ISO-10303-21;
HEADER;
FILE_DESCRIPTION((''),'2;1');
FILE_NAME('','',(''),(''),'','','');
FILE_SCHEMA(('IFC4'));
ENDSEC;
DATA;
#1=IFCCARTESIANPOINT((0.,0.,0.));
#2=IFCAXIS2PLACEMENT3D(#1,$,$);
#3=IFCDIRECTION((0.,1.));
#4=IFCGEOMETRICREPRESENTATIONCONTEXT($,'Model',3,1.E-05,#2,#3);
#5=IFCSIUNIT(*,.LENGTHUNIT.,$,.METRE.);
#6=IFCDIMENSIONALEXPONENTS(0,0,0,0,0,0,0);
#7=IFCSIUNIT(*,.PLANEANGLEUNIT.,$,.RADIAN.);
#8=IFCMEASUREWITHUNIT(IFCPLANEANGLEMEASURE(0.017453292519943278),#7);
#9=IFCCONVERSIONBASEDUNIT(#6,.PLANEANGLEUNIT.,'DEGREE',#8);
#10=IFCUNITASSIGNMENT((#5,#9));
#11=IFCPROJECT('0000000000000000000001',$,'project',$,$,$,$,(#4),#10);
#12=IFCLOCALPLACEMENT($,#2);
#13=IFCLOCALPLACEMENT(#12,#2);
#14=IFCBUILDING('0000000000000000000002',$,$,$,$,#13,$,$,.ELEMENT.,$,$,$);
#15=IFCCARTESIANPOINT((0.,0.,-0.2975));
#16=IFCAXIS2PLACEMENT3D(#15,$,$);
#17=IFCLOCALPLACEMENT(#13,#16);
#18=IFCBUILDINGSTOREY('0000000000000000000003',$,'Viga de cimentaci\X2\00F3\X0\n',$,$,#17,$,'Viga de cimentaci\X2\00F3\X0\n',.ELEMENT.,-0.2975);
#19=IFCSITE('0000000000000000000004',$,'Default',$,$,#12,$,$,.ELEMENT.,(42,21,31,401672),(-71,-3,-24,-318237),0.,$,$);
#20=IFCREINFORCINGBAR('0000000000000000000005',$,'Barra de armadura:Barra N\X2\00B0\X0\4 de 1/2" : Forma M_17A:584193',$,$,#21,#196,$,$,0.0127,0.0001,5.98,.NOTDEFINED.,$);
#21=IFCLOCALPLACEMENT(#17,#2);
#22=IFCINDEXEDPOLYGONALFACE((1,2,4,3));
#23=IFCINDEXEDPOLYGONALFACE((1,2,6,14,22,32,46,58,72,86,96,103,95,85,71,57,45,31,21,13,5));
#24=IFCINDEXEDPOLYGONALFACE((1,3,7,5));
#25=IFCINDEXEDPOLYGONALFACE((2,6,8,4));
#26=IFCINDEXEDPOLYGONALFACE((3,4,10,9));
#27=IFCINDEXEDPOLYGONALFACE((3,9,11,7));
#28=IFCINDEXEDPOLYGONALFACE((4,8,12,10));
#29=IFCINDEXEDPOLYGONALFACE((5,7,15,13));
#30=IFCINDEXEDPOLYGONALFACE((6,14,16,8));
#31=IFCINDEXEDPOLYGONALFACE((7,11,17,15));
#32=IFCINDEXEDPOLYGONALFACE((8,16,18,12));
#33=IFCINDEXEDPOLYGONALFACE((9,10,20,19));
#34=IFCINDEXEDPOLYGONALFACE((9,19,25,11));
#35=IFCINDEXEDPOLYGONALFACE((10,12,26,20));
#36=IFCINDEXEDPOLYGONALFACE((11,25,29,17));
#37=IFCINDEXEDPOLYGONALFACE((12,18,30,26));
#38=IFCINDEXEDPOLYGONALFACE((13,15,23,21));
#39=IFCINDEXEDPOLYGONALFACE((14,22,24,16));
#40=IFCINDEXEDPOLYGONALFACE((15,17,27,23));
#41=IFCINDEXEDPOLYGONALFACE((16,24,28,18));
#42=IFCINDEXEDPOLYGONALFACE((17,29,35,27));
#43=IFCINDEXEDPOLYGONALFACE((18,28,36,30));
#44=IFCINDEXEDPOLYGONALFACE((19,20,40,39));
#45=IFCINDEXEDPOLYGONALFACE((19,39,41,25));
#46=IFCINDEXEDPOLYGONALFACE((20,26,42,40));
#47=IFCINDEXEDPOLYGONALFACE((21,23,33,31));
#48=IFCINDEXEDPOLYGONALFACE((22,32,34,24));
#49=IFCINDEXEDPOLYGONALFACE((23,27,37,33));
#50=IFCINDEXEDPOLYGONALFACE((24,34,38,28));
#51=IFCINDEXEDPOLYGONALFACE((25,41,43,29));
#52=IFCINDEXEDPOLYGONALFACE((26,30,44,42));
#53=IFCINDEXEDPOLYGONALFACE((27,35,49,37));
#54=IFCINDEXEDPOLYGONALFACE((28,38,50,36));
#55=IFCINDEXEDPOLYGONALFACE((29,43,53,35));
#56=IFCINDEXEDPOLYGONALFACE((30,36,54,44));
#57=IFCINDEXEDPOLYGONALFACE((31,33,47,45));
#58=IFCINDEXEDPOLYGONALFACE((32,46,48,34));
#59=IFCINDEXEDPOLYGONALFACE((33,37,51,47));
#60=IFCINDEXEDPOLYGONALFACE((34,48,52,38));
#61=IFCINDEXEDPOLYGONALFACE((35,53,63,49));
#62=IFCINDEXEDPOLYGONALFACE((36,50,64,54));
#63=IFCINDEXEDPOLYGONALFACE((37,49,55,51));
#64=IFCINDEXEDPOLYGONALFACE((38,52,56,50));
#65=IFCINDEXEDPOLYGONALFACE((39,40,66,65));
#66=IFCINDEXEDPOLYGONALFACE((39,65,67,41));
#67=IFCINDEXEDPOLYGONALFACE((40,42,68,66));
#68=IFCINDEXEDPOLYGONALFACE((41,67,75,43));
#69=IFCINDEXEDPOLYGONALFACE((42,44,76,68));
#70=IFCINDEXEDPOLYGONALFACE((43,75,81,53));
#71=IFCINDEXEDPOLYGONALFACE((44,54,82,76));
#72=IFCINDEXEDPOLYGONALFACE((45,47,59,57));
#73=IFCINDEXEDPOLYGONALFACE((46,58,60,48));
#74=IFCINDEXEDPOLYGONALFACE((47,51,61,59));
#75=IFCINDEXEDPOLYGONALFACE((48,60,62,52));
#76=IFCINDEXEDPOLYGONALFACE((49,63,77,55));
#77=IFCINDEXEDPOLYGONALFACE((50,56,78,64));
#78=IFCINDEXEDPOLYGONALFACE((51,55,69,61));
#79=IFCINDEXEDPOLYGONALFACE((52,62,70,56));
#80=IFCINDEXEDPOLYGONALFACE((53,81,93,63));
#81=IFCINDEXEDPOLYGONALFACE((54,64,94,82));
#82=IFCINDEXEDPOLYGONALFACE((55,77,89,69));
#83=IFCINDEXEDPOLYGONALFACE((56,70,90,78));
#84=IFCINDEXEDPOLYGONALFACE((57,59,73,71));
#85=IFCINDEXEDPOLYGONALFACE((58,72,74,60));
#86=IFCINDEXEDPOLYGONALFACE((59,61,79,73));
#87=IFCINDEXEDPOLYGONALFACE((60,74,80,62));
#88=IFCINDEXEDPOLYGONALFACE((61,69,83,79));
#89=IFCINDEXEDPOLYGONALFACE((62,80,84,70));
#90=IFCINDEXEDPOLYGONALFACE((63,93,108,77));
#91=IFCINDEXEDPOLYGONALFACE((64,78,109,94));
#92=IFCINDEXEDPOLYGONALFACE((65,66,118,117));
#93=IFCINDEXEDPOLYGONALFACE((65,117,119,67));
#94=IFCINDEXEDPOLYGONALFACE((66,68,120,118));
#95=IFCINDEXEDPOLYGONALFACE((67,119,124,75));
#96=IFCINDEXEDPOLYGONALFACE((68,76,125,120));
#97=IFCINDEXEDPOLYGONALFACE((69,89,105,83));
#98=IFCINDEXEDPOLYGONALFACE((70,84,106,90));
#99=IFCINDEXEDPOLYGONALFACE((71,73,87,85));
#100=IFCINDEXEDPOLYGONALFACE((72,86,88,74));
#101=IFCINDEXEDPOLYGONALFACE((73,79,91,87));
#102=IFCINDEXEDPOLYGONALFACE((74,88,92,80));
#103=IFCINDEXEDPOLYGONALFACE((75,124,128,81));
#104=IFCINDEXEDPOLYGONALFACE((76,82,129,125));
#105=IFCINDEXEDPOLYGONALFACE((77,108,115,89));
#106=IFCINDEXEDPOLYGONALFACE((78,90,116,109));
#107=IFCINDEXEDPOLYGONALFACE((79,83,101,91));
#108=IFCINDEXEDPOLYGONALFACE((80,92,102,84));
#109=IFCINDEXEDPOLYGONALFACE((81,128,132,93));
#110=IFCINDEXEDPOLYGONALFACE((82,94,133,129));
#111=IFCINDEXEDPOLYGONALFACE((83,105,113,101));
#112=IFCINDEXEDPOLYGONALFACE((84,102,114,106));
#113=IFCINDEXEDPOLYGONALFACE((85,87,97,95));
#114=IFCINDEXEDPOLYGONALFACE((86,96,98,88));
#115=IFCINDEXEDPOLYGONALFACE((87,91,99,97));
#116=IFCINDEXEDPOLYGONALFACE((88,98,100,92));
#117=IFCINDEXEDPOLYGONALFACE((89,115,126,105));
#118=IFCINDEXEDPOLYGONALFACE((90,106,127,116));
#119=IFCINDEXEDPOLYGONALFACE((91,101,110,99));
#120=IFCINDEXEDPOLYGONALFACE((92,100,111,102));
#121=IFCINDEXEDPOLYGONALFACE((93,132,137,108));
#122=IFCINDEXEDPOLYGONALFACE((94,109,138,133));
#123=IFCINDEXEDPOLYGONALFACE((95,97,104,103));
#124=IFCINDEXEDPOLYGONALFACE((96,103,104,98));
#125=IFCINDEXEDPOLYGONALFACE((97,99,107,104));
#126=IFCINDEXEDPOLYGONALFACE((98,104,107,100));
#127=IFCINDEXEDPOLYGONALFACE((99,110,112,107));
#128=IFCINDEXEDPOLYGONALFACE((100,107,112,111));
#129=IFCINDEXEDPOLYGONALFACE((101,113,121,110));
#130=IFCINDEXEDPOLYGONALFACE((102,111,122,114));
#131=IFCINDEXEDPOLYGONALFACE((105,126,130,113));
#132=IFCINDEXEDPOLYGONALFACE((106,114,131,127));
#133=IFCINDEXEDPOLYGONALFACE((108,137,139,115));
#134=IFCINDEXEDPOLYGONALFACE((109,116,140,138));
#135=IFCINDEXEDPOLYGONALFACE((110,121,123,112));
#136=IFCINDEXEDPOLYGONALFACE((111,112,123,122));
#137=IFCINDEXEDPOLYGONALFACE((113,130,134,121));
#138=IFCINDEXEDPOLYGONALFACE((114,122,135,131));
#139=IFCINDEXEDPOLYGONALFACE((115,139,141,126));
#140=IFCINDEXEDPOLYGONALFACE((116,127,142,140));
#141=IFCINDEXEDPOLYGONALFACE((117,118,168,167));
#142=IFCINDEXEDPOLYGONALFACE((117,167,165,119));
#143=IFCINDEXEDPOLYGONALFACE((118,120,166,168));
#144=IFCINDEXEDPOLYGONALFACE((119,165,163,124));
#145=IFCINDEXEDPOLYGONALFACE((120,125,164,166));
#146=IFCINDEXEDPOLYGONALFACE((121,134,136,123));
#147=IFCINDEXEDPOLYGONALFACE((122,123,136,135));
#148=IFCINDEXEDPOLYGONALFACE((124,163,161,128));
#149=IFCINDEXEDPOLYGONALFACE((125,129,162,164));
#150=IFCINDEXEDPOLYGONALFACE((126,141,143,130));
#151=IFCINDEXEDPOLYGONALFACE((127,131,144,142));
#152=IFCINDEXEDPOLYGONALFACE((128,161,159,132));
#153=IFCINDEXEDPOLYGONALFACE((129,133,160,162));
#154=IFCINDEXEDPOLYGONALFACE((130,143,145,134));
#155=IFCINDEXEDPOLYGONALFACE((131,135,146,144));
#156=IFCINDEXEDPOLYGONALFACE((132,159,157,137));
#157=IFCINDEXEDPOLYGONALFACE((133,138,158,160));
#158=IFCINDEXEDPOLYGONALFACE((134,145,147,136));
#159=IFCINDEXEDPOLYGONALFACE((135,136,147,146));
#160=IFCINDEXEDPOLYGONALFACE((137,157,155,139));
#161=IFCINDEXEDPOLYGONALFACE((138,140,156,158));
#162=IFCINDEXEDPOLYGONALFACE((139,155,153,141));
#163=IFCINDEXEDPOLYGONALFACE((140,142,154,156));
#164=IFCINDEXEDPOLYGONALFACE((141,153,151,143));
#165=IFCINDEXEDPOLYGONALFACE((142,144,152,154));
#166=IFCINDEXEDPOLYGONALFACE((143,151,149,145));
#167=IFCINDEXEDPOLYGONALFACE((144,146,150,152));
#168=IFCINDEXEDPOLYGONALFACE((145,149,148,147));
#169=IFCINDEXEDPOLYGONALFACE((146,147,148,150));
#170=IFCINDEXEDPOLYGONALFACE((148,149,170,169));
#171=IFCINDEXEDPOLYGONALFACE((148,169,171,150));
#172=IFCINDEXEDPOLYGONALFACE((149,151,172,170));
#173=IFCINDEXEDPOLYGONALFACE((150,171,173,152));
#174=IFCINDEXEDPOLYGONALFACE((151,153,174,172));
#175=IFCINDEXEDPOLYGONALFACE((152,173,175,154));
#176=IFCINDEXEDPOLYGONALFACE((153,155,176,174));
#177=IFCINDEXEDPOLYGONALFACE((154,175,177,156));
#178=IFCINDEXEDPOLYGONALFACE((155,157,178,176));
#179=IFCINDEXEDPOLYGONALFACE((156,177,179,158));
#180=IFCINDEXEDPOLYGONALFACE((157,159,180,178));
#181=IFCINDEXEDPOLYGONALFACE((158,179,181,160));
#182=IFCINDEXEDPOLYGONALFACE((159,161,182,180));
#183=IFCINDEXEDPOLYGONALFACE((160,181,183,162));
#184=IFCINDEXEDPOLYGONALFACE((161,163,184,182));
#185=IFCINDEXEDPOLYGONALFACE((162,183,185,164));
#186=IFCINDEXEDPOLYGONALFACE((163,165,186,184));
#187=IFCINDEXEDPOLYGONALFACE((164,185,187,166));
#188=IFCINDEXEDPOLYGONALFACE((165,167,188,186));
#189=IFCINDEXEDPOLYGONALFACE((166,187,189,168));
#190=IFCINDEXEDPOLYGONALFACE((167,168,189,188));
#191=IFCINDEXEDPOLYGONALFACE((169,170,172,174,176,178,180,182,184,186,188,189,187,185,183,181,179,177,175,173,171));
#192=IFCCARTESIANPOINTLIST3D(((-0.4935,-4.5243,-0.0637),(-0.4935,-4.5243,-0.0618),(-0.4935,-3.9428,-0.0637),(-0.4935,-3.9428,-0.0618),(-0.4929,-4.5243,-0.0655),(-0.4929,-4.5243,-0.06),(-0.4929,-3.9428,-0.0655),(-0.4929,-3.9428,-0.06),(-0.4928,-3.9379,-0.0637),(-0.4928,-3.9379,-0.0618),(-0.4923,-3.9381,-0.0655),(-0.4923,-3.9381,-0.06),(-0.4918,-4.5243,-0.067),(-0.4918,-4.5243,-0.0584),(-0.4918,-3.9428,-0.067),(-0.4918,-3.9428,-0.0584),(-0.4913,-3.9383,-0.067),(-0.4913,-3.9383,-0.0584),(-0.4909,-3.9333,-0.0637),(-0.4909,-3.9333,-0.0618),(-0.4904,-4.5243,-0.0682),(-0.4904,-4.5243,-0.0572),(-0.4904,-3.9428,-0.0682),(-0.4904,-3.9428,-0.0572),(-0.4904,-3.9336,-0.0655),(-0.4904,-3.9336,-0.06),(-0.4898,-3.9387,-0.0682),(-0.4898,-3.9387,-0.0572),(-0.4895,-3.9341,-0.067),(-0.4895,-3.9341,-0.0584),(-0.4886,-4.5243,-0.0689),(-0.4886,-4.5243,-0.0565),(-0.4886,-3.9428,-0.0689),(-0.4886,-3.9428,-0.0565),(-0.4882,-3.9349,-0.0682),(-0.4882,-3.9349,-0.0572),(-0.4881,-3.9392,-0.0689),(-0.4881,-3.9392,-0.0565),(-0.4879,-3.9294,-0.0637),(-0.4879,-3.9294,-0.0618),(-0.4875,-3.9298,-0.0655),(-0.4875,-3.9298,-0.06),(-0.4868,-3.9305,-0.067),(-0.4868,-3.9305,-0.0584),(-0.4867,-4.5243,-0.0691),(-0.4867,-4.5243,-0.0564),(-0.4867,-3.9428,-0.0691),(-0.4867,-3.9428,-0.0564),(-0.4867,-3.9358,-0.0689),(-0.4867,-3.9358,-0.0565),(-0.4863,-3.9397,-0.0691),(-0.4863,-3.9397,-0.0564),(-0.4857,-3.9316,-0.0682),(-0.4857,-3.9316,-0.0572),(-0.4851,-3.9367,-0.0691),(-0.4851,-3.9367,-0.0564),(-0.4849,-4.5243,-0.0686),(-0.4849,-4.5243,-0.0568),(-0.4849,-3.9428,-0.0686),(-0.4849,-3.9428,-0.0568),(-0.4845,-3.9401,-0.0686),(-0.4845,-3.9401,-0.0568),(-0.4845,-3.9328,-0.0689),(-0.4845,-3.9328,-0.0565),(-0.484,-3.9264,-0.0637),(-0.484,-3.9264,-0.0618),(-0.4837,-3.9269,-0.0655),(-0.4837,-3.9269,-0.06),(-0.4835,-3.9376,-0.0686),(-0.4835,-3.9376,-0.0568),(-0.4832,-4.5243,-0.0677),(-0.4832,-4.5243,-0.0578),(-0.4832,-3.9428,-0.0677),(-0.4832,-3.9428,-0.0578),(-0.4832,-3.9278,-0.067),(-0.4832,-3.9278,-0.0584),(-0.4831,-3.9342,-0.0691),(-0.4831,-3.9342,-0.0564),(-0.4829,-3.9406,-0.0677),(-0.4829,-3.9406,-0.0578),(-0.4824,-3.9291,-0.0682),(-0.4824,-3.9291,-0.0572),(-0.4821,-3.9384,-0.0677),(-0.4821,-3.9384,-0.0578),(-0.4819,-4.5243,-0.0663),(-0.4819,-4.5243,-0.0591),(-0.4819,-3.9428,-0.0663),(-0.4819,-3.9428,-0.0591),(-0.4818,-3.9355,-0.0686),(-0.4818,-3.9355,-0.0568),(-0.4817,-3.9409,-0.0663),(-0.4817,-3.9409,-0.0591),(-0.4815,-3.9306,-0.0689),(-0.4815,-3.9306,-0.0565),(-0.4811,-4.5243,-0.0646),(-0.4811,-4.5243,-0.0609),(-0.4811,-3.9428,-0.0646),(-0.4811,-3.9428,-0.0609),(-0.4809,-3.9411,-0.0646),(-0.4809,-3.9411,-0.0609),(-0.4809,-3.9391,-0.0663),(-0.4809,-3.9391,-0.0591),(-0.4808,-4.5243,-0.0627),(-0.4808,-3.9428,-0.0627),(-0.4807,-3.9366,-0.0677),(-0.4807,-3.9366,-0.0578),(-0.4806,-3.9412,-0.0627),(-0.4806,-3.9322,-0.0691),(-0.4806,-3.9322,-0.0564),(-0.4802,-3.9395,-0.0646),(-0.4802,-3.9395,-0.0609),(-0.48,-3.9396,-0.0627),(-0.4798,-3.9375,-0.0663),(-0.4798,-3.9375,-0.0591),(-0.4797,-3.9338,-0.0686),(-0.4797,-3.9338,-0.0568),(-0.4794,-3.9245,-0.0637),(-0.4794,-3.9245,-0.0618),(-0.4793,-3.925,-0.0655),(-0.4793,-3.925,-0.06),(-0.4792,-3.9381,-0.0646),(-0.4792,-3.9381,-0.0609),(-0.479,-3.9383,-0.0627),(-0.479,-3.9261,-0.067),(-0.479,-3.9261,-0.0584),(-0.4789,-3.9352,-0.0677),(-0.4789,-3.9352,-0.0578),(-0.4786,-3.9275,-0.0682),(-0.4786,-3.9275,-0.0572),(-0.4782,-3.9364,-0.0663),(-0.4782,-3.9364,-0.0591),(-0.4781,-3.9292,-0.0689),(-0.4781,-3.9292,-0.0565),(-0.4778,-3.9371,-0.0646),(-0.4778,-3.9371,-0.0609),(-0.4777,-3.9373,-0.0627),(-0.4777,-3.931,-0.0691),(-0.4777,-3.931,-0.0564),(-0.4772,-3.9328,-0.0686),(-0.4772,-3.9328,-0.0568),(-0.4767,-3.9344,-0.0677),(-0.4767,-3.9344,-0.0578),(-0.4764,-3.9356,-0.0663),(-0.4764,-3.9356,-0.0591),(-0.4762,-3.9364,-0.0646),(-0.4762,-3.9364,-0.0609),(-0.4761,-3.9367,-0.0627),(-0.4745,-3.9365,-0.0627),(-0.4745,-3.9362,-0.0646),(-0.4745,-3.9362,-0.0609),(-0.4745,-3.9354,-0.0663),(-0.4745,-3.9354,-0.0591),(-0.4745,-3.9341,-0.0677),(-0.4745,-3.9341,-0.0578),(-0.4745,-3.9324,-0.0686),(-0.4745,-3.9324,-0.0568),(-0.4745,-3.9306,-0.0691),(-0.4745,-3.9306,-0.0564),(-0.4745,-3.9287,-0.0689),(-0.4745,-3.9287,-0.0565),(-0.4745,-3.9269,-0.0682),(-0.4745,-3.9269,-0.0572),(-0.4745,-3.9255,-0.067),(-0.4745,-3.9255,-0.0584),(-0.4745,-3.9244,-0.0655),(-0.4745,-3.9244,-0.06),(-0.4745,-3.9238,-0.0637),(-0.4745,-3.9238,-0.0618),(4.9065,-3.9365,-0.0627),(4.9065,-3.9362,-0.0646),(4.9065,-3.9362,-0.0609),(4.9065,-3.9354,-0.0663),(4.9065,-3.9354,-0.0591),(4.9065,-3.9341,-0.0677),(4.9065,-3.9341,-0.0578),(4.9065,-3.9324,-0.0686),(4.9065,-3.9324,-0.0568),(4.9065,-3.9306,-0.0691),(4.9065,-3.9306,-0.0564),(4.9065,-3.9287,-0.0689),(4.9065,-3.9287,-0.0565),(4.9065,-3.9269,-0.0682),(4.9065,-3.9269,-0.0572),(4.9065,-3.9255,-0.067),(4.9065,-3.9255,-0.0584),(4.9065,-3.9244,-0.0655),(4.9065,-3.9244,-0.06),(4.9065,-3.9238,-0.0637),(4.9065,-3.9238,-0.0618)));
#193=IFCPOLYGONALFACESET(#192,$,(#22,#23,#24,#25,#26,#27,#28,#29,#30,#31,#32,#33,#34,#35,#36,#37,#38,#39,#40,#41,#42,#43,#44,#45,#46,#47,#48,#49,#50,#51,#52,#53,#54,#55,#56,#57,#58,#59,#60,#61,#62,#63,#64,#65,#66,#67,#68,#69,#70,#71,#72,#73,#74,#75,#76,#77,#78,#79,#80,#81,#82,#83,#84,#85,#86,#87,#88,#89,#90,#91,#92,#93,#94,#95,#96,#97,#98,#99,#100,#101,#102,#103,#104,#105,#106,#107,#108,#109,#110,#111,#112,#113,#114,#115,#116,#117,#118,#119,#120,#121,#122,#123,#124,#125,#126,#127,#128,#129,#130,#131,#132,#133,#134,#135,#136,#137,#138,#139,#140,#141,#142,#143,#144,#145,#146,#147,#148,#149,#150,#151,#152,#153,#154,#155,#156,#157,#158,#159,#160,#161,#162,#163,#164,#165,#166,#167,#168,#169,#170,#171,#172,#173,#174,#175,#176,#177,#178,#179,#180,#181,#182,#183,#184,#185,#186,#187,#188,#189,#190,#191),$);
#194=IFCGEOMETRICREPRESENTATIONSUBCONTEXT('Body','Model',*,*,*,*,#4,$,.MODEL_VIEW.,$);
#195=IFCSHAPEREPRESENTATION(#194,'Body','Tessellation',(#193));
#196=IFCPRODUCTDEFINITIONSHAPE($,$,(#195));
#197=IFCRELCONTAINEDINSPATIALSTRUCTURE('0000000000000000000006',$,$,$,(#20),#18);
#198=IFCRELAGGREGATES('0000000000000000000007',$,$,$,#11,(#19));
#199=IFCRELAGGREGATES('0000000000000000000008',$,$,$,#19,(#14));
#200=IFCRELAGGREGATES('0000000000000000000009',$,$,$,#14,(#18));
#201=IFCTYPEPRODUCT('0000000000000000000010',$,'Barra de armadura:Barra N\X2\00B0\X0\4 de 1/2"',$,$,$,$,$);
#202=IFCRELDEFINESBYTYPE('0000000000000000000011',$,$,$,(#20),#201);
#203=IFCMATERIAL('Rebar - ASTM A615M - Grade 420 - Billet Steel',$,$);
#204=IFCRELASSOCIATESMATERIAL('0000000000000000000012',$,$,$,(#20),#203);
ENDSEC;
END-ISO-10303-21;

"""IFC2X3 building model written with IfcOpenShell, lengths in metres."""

from ifc_helpers import new_model, entity, si_unit, converted_unit, direction, frame, origin, place, context, subcontext, project, spatial, material, type_object, element, save


model = new_model("IFC2X3")

# Units and contexts
model_context = context("Model", 3, precision=1e-05, world=origin(), true_north=direction((0.0, 1.0)))
body_context = subcontext(model_context, "Body", "Model", "MODEL_VIEW")
ifc_project = project(units=[si_unit("LENGTHUNIT", "METRE"), converted_unit("PLANEANGLEUNIT", "DEGREE", entity("IfcPlaneAngleMeasure", 0.017453292519943278), si_unit("PLANEANGLEUNIT", "RADIAN"), dimensions=[0, 0, 0, 0, 0, 0, 0])], contexts=[model_context])

# Site, building, storey
site_placement = place(None, origin())
site = spatial("IfcSite", under=ifc_project, at=site_placement, Name="Default", CompositionType="ELEMENT", RefLatitude=(42, 21, 31, 401672), RefLongitude=(-71, -3, -24, -318237), RefElevation=0.0)
building_placement = place(site_placement, origin())
building = spatial("IfcBuilding", under=site, at=building_placement, CompositionType="ELEMENT")
storey_placement = place(building_placement, frame((0.0, 0.0, -0.2975)))
storey = spatial("IfcBuildingStorey", under=building, at=storey_placement, Name="Viga de cimentación", LongName="Viga de cimentación", CompositionType="ELEMENT", Elevation=-0.2975)

# Reinforcing bar
ifc_material = material(Name="Rebar - ASTM A615M - Grade 420 - Billet Steel")
type_product_1 = type_object("IfcTypeProduct", Name="Barra de armadura:Barra N°4 de 1/2\"")
reinforcing_bar_1_placement = place(storey_placement, origin())
element("IfcReinforcingBar", 1, at=reinforcing_bar_1_placement, inside=storey, type_object=type_product_1, material=ifc_material, Name="Barra de armadura:Barra N°4 de 1/2\" : Forma M_17A:584193", BarLength=5.98, BarRole="NOTDEFINED", CrossSectionArea=0.0001, NominalDiameter=0.0127, context=body_context, shape_type="AdvancedSweptSolid", body=[
    entity("IfcSweptDiskSolid", entity("IfcCompositeCurve", [entity("IfcCompositeCurveSegment", "CONTINUOUS", True, entity("IfcPolyline", [entity("IfcCartesianPoint", [-0.4872, -4.5243, -0.0627]), entity("IfcCartesianPoint", [-0.4872, -3.9428, -0.0627])])), entity("IfcCompositeCurveSegment", "CONTINUOUS", True, entity("IfcTrimmedCurve", entity("IfcCircle", entity("IfcAxis2Placement3D", entity("IfcCartesianPoint", [-0.4745, -3.9428, -0.0627]), entity("IfcDirection", [0.0, 0.0, -1.0]), entity("IfcDirection", [0.0, 1.0, 0.0])), 0.0127), [entity("IfcParameterValue", 270.0)], [entity("IfcParameterValue", 360.0)], True, "PARAMETER")), entity("IfcCompositeCurveSegment", "CONTINUOUS", True, entity("IfcPolyline", [entity("IfcCartesianPoint", [-0.4745, -3.9301, -0.0627]), entity("IfcCartesianPoint", [4.9065, -3.9301, -0.0627])]))], False), 0.0063, None, 0.0, 92.0),
])

save(model, "model.ifc")
